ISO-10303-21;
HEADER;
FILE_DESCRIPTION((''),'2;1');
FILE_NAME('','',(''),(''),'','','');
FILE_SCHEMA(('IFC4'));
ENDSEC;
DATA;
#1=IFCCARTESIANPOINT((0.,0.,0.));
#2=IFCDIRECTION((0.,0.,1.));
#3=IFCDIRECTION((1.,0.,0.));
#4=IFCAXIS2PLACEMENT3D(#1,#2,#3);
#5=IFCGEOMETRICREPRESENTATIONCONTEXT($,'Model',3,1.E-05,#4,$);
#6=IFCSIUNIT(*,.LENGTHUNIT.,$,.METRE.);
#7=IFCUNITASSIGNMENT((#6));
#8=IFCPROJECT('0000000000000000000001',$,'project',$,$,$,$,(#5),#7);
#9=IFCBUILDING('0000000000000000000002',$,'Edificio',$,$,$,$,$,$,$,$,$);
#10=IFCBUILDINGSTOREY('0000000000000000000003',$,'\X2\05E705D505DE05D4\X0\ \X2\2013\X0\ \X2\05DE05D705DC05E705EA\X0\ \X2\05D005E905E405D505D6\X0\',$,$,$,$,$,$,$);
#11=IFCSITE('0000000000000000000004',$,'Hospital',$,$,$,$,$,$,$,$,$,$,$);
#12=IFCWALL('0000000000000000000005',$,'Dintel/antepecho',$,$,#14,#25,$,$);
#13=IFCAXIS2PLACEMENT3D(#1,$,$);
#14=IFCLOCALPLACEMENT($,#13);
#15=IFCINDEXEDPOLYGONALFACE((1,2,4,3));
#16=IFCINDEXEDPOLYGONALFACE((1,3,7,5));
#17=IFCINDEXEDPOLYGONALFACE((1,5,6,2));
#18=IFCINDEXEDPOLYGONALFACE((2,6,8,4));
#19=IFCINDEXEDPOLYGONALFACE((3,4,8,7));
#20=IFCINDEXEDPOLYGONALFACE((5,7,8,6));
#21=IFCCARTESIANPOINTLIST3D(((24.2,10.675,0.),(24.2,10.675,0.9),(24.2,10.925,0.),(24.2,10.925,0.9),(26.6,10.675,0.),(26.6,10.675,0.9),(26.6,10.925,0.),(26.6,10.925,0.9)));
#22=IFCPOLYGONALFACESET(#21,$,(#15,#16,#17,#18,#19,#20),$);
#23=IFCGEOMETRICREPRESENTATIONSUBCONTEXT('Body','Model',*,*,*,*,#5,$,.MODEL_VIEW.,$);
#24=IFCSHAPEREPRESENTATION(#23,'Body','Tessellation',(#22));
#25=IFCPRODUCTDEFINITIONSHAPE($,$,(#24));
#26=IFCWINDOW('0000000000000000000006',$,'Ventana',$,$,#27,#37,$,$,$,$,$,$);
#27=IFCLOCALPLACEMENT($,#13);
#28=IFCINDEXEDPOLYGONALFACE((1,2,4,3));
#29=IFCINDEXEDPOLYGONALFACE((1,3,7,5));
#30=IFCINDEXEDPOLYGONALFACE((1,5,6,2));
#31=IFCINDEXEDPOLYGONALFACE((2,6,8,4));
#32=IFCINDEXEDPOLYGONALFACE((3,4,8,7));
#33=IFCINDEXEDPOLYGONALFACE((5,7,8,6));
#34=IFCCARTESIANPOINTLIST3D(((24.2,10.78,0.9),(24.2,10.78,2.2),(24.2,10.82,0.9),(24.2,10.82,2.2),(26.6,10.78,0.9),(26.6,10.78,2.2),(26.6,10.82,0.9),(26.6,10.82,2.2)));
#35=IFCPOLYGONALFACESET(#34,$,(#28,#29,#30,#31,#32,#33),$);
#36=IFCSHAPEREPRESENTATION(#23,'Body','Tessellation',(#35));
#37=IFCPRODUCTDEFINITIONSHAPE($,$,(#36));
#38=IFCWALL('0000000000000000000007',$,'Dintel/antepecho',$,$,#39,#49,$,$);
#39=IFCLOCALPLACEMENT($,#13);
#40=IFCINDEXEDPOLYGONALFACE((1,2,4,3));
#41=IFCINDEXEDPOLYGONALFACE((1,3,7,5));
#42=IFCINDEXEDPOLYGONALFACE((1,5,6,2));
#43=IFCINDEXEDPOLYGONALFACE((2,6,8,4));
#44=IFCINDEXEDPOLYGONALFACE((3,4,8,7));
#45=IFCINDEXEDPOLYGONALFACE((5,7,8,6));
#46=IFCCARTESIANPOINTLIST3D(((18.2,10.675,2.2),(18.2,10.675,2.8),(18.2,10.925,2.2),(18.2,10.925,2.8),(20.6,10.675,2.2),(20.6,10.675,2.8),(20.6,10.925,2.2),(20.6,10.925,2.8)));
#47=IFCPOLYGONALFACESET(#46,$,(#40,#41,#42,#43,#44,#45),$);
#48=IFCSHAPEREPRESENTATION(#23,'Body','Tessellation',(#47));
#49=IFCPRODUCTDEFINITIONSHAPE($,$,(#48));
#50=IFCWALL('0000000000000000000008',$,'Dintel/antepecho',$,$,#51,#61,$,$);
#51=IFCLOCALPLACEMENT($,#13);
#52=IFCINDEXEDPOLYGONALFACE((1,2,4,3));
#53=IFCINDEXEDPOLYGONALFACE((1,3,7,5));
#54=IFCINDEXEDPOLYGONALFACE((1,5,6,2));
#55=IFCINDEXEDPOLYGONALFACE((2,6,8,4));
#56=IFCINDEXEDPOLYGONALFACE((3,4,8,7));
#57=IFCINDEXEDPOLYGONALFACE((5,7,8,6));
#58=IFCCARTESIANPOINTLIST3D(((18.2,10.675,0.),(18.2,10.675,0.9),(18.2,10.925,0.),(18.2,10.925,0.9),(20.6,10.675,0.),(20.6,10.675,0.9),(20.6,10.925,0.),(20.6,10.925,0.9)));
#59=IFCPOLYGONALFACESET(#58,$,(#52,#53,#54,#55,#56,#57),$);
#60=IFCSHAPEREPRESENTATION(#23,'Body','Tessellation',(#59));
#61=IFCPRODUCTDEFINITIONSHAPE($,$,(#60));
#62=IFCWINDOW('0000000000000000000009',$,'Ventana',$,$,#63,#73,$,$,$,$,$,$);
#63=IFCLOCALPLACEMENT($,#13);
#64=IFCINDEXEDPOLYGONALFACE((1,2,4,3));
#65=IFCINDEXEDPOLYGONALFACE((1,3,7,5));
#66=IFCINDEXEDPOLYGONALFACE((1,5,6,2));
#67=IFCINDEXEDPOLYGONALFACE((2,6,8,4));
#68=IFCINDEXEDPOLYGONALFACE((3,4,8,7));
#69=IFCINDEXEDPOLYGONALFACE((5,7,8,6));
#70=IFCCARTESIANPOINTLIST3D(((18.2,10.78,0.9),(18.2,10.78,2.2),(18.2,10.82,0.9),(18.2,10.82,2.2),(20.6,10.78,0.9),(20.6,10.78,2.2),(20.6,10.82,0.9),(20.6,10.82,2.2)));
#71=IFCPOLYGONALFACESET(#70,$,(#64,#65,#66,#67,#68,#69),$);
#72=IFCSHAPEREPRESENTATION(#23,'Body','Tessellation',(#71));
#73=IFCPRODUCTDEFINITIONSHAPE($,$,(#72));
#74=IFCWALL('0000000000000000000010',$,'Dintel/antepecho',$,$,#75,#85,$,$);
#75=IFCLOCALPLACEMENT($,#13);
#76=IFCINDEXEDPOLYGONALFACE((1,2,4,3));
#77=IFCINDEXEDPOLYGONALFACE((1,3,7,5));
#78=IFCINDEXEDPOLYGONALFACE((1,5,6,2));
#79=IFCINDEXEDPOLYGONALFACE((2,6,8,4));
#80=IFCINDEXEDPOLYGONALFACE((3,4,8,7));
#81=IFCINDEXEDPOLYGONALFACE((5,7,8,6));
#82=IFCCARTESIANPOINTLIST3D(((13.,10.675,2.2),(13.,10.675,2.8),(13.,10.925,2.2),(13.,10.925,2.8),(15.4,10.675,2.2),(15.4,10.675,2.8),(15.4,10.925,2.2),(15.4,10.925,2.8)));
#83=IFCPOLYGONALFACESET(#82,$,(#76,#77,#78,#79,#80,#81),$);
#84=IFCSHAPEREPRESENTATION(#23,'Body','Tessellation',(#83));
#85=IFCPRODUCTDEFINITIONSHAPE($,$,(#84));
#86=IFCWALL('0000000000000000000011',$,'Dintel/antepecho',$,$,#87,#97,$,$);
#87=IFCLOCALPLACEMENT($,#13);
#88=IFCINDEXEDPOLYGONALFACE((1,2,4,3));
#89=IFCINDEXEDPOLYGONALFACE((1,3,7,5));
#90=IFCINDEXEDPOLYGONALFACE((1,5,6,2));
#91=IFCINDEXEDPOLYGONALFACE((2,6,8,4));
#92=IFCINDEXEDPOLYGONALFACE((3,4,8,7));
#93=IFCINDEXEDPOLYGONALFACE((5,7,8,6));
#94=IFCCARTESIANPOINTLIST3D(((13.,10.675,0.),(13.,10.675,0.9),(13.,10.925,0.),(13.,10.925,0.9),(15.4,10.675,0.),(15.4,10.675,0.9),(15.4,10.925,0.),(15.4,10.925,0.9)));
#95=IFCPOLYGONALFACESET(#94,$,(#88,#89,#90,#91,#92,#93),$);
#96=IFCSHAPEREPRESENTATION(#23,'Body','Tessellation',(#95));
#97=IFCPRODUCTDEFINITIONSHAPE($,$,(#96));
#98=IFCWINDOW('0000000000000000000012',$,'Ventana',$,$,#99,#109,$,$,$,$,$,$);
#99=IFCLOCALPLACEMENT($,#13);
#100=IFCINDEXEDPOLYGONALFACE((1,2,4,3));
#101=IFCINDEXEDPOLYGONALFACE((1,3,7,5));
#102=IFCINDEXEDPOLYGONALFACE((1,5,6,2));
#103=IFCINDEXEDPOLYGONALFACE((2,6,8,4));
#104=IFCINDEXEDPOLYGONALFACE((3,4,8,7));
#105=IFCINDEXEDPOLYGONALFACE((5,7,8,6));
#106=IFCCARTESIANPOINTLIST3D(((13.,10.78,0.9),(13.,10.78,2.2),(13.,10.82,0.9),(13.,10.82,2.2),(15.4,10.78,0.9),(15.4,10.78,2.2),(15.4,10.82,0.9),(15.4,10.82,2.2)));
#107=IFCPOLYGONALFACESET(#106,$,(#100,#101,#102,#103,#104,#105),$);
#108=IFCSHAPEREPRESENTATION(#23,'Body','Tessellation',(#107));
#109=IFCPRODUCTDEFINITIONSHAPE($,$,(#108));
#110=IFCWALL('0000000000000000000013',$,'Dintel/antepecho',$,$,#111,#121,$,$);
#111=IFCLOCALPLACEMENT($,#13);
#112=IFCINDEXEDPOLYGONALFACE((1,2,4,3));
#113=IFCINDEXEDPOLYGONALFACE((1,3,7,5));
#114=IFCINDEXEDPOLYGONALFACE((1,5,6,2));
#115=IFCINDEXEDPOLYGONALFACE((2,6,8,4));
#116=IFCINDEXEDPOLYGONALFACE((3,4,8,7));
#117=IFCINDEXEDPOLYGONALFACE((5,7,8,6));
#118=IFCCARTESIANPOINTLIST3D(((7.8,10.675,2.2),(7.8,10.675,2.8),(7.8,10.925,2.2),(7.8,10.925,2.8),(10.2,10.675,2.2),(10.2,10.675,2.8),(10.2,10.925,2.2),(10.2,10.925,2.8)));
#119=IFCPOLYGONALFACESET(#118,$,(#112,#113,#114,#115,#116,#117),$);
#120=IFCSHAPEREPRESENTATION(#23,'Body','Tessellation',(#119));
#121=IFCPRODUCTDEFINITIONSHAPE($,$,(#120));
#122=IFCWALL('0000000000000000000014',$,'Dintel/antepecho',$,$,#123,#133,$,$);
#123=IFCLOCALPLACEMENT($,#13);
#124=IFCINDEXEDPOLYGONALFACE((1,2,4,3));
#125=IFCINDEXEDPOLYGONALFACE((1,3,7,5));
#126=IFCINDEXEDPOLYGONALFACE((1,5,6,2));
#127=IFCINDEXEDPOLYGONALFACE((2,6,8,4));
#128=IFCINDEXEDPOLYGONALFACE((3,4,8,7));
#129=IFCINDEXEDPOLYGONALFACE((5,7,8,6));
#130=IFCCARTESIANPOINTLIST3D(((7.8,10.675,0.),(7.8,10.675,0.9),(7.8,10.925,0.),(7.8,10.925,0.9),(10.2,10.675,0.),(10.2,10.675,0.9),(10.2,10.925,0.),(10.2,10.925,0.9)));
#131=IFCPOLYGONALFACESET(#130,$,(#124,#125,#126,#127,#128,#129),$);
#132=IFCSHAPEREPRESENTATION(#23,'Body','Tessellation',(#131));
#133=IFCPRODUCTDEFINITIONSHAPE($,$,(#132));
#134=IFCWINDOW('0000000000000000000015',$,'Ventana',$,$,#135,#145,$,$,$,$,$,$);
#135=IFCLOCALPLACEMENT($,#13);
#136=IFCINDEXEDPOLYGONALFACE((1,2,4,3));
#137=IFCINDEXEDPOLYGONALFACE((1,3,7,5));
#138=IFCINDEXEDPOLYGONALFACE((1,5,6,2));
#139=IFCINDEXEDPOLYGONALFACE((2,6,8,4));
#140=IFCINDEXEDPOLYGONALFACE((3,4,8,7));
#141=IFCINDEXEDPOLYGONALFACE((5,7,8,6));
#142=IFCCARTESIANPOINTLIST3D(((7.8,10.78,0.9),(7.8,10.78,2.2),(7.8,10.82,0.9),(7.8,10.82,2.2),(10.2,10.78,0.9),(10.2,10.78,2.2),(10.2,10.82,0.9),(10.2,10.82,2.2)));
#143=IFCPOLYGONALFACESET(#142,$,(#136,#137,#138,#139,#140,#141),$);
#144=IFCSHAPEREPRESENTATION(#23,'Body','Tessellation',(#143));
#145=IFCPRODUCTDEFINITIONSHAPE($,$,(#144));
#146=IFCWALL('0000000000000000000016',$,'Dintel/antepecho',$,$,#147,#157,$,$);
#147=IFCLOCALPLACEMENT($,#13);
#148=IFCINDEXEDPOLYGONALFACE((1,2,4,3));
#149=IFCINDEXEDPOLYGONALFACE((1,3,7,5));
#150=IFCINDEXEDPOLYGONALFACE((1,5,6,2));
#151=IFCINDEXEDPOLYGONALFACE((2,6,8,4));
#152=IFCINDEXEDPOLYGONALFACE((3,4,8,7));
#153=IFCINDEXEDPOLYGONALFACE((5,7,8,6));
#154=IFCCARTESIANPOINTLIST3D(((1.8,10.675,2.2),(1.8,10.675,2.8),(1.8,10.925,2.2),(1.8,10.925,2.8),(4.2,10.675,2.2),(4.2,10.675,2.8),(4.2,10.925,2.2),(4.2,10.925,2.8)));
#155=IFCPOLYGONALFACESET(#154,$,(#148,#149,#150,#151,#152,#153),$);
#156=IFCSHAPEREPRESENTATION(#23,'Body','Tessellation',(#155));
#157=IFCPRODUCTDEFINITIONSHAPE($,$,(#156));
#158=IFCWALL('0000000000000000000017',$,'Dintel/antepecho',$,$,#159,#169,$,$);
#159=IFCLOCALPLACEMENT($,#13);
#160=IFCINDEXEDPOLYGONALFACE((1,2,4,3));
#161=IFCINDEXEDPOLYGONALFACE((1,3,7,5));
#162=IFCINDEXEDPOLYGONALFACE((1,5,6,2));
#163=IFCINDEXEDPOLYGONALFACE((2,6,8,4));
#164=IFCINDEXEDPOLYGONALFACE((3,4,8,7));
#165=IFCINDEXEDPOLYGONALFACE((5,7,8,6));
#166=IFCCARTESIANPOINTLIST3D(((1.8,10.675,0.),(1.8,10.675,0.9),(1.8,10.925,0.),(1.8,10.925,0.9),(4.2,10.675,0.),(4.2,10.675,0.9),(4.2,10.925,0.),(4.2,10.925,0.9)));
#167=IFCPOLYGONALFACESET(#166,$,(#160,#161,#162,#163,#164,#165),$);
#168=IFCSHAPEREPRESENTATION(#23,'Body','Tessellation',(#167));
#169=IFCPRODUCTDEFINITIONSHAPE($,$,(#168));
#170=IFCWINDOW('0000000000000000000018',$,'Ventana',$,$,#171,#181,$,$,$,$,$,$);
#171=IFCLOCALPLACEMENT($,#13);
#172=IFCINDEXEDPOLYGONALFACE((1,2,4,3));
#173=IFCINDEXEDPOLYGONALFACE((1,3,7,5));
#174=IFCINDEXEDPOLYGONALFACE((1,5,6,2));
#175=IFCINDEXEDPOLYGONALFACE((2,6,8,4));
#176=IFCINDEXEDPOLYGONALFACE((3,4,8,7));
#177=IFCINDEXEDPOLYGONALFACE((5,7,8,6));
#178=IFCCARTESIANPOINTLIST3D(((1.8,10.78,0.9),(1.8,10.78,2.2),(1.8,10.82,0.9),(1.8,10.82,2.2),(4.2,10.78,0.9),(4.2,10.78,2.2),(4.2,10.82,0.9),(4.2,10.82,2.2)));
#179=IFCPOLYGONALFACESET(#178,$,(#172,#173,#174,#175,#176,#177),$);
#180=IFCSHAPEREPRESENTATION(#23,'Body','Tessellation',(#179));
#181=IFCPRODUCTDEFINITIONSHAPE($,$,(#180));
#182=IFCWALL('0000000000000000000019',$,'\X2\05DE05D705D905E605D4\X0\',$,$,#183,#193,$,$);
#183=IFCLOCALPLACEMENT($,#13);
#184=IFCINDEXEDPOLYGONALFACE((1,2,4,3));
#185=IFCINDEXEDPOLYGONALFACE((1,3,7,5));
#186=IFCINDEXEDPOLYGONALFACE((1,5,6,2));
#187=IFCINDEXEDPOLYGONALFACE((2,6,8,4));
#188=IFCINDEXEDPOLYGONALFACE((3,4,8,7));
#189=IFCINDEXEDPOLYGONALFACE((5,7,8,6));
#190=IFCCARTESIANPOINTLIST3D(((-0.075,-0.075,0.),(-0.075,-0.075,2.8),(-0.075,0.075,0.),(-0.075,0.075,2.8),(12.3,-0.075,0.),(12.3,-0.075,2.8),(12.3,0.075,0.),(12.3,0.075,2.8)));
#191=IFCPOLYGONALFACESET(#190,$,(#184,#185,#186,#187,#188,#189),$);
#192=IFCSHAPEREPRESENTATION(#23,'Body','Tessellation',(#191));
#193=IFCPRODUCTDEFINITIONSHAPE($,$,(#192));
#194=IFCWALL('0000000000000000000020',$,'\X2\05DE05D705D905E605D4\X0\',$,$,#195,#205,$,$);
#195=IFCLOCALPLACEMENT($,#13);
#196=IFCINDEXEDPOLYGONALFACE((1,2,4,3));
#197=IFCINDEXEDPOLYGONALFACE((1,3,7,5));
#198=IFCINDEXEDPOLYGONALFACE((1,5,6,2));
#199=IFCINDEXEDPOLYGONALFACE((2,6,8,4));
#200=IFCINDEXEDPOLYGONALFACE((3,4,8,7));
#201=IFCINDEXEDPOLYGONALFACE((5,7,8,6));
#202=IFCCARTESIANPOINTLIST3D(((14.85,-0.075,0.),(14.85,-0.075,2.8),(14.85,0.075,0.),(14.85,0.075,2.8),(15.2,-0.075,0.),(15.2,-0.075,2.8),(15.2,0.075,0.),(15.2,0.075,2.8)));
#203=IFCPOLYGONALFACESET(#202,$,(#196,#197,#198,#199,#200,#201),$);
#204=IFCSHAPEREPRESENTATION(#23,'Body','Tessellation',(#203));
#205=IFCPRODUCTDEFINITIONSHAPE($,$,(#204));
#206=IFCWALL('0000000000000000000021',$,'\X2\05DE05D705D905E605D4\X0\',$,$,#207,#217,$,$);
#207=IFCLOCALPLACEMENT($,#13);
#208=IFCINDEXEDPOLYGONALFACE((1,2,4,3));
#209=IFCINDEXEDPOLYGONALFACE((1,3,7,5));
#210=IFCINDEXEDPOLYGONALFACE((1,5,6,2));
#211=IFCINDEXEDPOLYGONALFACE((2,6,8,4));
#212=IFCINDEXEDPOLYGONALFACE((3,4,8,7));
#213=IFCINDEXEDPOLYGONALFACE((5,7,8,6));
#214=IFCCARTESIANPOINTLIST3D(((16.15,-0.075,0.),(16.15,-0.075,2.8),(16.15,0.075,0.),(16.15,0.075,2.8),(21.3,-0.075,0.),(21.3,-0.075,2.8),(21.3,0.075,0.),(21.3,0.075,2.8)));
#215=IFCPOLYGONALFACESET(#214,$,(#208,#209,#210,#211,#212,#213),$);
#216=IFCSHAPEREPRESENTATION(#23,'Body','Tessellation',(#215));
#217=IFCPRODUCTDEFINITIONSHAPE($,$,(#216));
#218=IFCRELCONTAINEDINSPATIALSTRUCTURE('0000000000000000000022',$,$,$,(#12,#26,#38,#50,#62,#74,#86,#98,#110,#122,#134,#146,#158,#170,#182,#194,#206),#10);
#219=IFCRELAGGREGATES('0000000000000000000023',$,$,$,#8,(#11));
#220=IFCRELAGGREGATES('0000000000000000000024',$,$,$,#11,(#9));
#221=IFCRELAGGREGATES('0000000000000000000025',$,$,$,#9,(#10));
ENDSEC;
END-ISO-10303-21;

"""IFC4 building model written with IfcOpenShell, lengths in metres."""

from ifc_helpers import new_model, si_unit, frame, origin_with_axes, context, subcontext, project, spatial, line, indexed_curve, outline, extrude, element, save


model = new_model("IFC4")

# Units and contexts
model_context = context("Model", 3, precision=1e-05, world=origin_with_axes())
body_context = subcontext(model_context, "Body", "Model", "MODEL_VIEW")
ifc_project = project(units=[si_unit("LENGTHUNIT", "METRE")], contexts=[model_context])

# Site, building, storey
site = spatial("IfcSite", under=ifc_project, Name="Hospital")
building = spatial("IfcBuilding", under=site, Name="Edificio")
storey = spatial("IfcBuildingStorey", under=building, Name="קומה – מחלקת אשפוז")

# Wall
element("IfcWall", 1, inside=storey, Name="Dintel/antepecho", context=body_context, shape_type="SweptSolid", body=[
    extrude(outline(indexed_curve([(0.0, 0.0), (2.4, 0.0), (2.4, 0.25), (0.0, 0.25)], segments=[line(1, 2, 3, 4, 1)])), frame((24.2, 10.675, 0.0), z_axis=(0.0, 0.0, 1.0), x_axis=(1.0, 0.0, 0.0)), (0.0, 0.0, 1.0), 0.9),
])

# Window
element("IfcWindow", 2, inside=storey, Name="Ventana", context=body_context, shape_type="SweptSolid", body=[
    extrude(outline(indexed_curve([(0.0, 0.0), (2.4, 0.0), (2.4, 0.04), (0.0, 0.04)], segments=[line(1, 2, 3, 4, 1)])), frame((24.2, 10.78, 0.9), z_axis=(0.0, 0.0, 1.0), x_axis=(1.0, 0.0, 0.0)), (0.0, 0.0, 1.0), 1.3),
])

# Walls
element("IfcWall", 3, inside=storey, Name="Dintel/antepecho", context=body_context, shape_type="SweptSolid", body=[
    extrude(outline(indexed_curve([(0.0, 0.0), (2.4, 0.0), (2.4, 0.25), (0.0, 0.25)], segments=[line(1, 2, 3, 4, 1)])), frame((18.2, 10.675, 2.2), z_axis=(0.0, 0.0, 1.0), x_axis=(1.0, 0.0, 0.0)), (0.0, 0.0, 1.0), 0.6),
])
element("IfcWall", 4, inside=storey, Name="Dintel/antepecho", context=body_context, shape_type="SweptSolid", body=[
    extrude(outline(indexed_curve([(0.0, 0.0), (2.4, 0.0), (2.4, 0.25), (0.0, 0.25)], segments=[line(1, 2, 3, 4, 1)])), frame((18.2, 10.675, 0.0), z_axis=(0.0, 0.0, 1.0), x_axis=(1.0, 0.0, 0.0)), (0.0, 0.0, 1.0), 0.9),
])

# Window
element("IfcWindow", 5, inside=storey, Name="Ventana", context=body_context, shape_type="SweptSolid", body=[
    extrude(outline(indexed_curve([(0.0, 0.0), (2.4, 0.0), (2.4, 0.04), (0.0, 0.04)], segments=[line(1, 2, 3, 4, 1)])), frame((18.2, 10.78, 0.9), z_axis=(0.0, 0.0, 1.0), x_axis=(1.0, 0.0, 0.0)), (0.0, 0.0, 1.0), 1.3),
])

# Walls
element("IfcWall", 6, inside=storey, Name="Dintel/antepecho", context=body_context, shape_type="SweptSolid", body=[
    extrude(outline(indexed_curve([(0.0, 0.0), (2.4, 0.0), (2.4, 0.25), (0.0, 0.25)], segments=[line(1, 2, 3, 4, 1)])), frame((13.0, 10.675, 2.2), z_axis=(0.0, 0.0, 1.0), x_axis=(1.0, 0.0, 0.0)), (0.0, 0.0, 1.0), 0.6),
])
element("IfcWall", 7, inside=storey, Name="Dintel/antepecho", context=body_context, shape_type="SweptSolid", body=[
    extrude(outline(indexed_curve([(0.0, 0.0), (2.4, 0.0), (2.4, 0.25), (0.0, 0.25)], segments=[line(1, 2, 3, 4, 1)])), frame((13.0, 10.675, 0.0), z_axis=(0.0, 0.0, 1.0), x_axis=(1.0, 0.0, 0.0)), (0.0, 0.0, 1.0), 0.9),
])

# Window
element("IfcWindow", 8, inside=storey, Name="Ventana", context=body_context, shape_type="SweptSolid", body=[
    extrude(outline(indexed_curve([(0.0, 0.0), (2.4, 0.0), (2.4, 0.04), (0.0, 0.04)], segments=[line(1, 2, 3, 4, 1)])), frame((13.0, 10.78, 0.9), z_axis=(0.0, 0.0, 1.0), x_axis=(1.0, 0.0, 0.0)), (0.0, 0.0, 1.0), 1.3),
])

# Walls
element("IfcWall", 9, inside=storey, Name="Dintel/antepecho", context=body_context, shape_type="SweptSolid", body=[
    extrude(outline(indexed_curve([(0.0, 0.0), (2.4, 0.0), (2.4, 0.25), (0.0, 0.25)], segments=[line(1, 2, 3, 4, 1)])), frame((7.8, 10.675, 2.2), z_axis=(0.0, 0.0, 1.0), x_axis=(1.0, 0.0, 0.0)), (0.0, 0.0, 1.0), 0.6),
])
element("IfcWall", 10, inside=storey, Name="Dintel/antepecho", context=body_context, shape_type="SweptSolid", body=[
    extrude(outline(indexed_curve([(0.0, 0.0), (2.4, 0.0), (2.4, 0.25), (0.0, 0.25)], segments=[line(1, 2, 3, 4, 1)])), frame((7.8, 10.675, 0.0), z_axis=(0.0, 0.0, 1.0), x_axis=(1.0, 0.0, 0.0)), (0.0, 0.0, 1.0), 0.9),
])

# Window
element("IfcWindow", 11, inside=storey, Name="Ventana", context=body_context, shape_type="SweptSolid", body=[
    extrude(outline(indexed_curve([(0.0, 0.0), (2.4, 0.0), (2.4, 0.04), (0.0, 0.04)], segments=[line(1, 2, 3, 4, 1)])), frame((7.8, 10.78, 0.9), z_axis=(0.0, 0.0, 1.0), x_axis=(1.0, 0.0, 0.0)), (0.0, 0.0, 1.0), 1.3),
])

# Walls
element("IfcWall", 12, inside=storey, Name="Dintel/antepecho", context=body_context, shape_type="SweptSolid", body=[
    extrude(outline(indexed_curve([(0.0, 0.0), (2.4, 0.0), (2.4, 0.25), (0.0, 0.25)], segments=[line(1, 2, 3, 4, 1)])), frame((1.8, 10.675, 2.2), z_axis=(0.0, 0.0, 1.0), x_axis=(1.0, 0.0, 0.0)), (0.0, 0.0, 1.0), 0.6),
])
element("IfcWall", 13, inside=storey, Name="Dintel/antepecho", context=body_context, shape_type="SweptSolid", body=[
    extrude(outline(indexed_curve([(0.0, 0.0), (2.4, 0.0), (2.4, 0.25), (0.0, 0.25)], segments=[line(1, 2, 3, 4, 1)])), frame((1.8, 10.675, 0.0), z_axis=(0.0, 0.0, 1.0), x_axis=(1.0, 0.0, 0.0)), (0.0, 0.0, 1.0), 0.9),
])

# Window
element("IfcWindow", 14, inside=storey, Name="Ventana", context=body_context, shape_type="SweptSolid", body=[
    extrude(outline(indexed_curve([(0.0, 0.0), (2.4, 0.0), (2.4, 0.04), (0.0, 0.04)], segments=[line(1, 2, 3, 4, 1)])), frame((1.8, 10.78, 0.9), z_axis=(0.0, 0.0, 1.0), x_axis=(1.0, 0.0, 0.0)), (0.0, 0.0, 1.0), 1.3),
])

# Walls
element("IfcWall", 15, inside=storey, Name="מחיצה", context=body_context, shape_type="SweptSolid", body=[
    extrude(outline(indexed_curve([(0.0, 0.0), (12.375, 0.0), (12.375, 0.15), (0.0, 0.15)], segments=[line(1, 2, 3, 4, 1)])), frame((-0.075, -0.075, 0.0), z_axis=(0.0, 0.0, 1.0), x_axis=(1.0, 0.0, 0.0)), (0.0, 0.0, 1.0), 2.8),
])
element("IfcWall", 16, inside=storey, Name="מחיצה", context=body_context, shape_type="SweptSolid", body=[
    extrude(outline(indexed_curve([(0.0, 0.0), (0.35, 0.0), (0.35, 0.15), (0.0, 0.15)], segments=[line(1, 2, 3, 4, 1)])), frame((14.85, -0.075, 0.0), z_axis=(0.0, 0.0, 1.0), x_axis=(1.0, 0.0, 0.0)), (0.0, 0.0, 1.0), 2.8),
])
element("IfcWall", 17, inside=storey, Name="מחיצה", context=body_context, shape_type="SweptSolid", body=[
    extrude(outline(indexed_curve([(0.0, 0.0), (5.15, 0.0), (5.15, 0.15), (0.0, 0.15)], segments=[line(1, 2, 3, 4, 1)])), frame((16.15, -0.075, 0.0), z_axis=(0.0, 0.0, 1.0), x_axis=(1.0, 0.0, 0.0)), (0.0, 0.0, 1.0), 2.8),
])

save(model, "model.ifc")
